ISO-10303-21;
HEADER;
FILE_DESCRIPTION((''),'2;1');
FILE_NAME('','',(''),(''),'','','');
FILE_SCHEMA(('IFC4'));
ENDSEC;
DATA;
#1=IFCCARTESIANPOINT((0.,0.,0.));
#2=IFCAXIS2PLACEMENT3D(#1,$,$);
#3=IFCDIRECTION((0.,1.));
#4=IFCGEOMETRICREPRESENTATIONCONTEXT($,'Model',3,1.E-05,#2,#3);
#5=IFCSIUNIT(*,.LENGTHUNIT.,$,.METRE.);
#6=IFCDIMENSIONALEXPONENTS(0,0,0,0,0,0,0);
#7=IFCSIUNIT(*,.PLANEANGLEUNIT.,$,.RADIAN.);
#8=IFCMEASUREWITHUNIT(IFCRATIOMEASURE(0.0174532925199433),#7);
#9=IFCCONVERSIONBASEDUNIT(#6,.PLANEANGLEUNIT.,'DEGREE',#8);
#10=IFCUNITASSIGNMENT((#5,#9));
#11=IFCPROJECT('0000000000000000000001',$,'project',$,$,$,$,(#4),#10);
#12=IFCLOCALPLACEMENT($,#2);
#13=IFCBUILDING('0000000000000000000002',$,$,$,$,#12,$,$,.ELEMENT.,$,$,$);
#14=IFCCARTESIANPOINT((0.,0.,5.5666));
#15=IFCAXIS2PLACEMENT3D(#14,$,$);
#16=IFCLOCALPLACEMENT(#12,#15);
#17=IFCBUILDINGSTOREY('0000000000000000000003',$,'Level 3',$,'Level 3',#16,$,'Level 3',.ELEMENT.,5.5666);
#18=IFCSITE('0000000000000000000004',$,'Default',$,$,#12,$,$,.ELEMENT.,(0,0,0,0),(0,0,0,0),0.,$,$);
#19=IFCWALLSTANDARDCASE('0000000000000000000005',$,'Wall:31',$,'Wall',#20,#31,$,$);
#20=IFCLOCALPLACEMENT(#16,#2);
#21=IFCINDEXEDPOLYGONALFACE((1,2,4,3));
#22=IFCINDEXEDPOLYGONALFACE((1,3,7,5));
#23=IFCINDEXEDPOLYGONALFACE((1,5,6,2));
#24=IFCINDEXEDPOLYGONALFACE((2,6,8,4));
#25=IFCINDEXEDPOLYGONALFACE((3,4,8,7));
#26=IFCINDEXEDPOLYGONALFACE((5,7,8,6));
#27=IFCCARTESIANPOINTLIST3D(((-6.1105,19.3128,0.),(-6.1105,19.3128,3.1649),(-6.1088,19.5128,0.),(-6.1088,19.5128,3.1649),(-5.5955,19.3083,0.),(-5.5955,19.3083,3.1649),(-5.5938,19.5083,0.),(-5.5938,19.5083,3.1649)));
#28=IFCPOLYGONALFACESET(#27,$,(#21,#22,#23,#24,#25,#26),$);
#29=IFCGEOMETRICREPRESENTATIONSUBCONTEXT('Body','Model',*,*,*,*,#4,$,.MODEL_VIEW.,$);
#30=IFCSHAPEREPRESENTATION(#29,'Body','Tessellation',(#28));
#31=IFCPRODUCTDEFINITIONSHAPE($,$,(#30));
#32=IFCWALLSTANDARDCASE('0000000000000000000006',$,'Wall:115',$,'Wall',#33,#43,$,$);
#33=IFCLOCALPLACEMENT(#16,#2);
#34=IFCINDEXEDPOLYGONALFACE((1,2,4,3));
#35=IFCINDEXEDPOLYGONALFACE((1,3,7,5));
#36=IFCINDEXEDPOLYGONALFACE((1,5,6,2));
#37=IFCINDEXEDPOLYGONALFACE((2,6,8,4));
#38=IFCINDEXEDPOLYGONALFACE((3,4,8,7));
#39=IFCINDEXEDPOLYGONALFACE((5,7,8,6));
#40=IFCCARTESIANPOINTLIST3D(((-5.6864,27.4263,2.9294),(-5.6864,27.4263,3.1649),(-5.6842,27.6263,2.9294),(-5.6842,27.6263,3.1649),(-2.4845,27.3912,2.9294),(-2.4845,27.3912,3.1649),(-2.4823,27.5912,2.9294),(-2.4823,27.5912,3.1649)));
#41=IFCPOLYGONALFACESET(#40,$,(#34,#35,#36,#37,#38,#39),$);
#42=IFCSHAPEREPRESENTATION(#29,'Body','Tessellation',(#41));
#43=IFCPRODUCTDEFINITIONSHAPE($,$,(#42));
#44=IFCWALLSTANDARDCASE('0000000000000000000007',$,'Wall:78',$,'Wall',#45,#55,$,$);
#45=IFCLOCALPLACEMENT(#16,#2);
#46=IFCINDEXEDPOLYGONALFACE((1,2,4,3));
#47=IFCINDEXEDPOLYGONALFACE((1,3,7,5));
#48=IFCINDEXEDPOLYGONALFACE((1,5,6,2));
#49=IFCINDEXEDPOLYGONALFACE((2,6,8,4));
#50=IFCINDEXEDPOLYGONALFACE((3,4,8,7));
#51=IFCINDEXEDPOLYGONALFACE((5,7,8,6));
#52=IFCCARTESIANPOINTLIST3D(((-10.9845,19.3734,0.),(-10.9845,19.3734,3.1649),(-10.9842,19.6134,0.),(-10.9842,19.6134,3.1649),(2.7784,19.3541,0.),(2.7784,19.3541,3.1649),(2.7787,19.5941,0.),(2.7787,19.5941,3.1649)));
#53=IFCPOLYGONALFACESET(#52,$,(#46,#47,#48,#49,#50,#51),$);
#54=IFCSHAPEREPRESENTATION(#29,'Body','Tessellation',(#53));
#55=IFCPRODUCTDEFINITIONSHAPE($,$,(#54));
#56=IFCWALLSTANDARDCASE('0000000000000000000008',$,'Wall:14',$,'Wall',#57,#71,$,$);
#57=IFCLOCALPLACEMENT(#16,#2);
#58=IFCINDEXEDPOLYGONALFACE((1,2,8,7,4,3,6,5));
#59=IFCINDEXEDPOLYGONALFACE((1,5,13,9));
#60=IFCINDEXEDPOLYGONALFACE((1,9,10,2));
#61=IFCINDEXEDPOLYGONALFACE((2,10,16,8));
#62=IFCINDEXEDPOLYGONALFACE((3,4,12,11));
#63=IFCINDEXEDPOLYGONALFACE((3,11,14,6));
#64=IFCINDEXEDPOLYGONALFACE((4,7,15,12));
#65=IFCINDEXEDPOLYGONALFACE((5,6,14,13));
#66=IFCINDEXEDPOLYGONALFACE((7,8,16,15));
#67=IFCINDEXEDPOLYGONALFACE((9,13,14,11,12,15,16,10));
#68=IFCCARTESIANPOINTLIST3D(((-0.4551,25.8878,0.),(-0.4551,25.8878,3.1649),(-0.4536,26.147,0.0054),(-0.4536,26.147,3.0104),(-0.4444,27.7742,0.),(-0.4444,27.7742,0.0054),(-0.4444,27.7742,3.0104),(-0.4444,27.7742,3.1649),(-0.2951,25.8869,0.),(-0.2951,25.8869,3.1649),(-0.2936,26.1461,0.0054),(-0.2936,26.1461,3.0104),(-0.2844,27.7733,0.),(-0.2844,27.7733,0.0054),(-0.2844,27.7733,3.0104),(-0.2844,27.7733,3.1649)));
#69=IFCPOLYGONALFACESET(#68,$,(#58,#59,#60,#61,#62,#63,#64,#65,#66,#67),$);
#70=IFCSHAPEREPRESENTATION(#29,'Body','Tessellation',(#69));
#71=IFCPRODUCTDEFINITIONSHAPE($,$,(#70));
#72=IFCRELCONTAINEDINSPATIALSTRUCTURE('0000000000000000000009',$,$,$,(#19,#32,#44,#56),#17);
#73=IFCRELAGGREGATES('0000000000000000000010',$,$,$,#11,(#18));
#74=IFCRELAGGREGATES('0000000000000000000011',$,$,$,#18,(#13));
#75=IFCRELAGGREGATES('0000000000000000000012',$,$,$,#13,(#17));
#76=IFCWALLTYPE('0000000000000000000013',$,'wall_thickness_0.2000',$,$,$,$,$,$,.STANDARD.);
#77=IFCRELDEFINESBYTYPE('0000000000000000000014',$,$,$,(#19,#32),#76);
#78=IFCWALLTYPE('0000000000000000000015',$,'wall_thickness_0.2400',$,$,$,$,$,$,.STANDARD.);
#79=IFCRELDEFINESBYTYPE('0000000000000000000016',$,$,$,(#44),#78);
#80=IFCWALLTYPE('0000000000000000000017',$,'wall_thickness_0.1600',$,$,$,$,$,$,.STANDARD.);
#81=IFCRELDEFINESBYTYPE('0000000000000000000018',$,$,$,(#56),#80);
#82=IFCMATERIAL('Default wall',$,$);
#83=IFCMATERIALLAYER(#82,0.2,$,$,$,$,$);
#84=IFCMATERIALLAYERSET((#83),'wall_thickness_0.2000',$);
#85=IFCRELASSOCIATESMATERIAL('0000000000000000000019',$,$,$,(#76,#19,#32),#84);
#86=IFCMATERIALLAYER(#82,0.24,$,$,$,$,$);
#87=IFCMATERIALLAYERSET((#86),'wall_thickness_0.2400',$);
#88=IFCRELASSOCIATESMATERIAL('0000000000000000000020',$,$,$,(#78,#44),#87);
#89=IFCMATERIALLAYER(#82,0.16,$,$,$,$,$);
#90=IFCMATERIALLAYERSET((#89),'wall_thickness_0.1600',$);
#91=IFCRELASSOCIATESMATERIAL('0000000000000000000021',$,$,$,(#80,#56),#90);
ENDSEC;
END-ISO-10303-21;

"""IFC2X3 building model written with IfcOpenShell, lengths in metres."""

from ifc_helpers import new_model, entity, si_unit, converted_unit, direction, frame, frame_2d, origin, place, context, subcontext, project, spatial, polyline, rectangle, outline, extrude, material, layer, layer_set, layer_usage, type_object, element, save


model = new_model("IFC2X3")

# Units and contexts
model_context = context("Model", 3, precision=1e-05, world=origin(), true_north=direction((0.0, 1.0)))
body_context = subcontext(model_context, "Body", "Model", "MODEL_VIEW")
ifc_project = project(units=[si_unit("LENGTHUNIT", "METRE"), converted_unit("PLANEANGLEUNIT", "DEGREE", entity("IfcRatioMeasure", 0.0174532925199433), si_unit("PLANEANGLEUNIT", "RADIAN"), dimensions=[0, 0, 0, 0, 0, 0, 0])], contexts=[model_context])

# Site, building, storey
placement_1 = place(None, origin())
site = spatial("IfcSite", under=ifc_project, at=placement_1, Name="Default", CompositionType="ELEMENT", RefLatitude=(0, 0, 0, 0), RefLongitude=(0, 0, 0, 0), RefElevation=0.0)
building = spatial("IfcBuilding", under=site, at=placement_1, CompositionType="ELEMENT")
storey_placement = place(placement_1, frame((0.0, 0.0, 5.5666)))
storey = spatial("IfcBuildingStorey", under=building, at=storey_placement, Name="Level 3", ObjectType="Level 3", LongName="Level 3", CompositionType="ELEMENT", Elevation=5.5666)

# Shared definitions
ifc_material_1 = material(Name="Default wall")

# Walls
ifc_layer_1 = layer(ifc_material_1, 0.2)
ifc_layer_set_1 = layer_set([ifc_layer_1], Name="wall_thickness_0.2000")
ifc_layer_usage_1 = layer_usage(ifc_layer_set_1, "AXIS2", "POSITIVE", -0.1)
wall_type_1 = type_object("IfcWallType", Name="wall_thickness_0.2000", PredefinedType="STANDARD", material=ifc_layer_set_1)
wall_1_placement = place(storey_placement, frame((-6.1097, 19.4128, 0.0), z_axis=(0.0, 0.0, 1.0), x_axis=(0.999962, -0.008726, 0.0)))
element("IfcWallStandardCase", 1, at=wall_1_placement, inside=storey, type_object=wall_type_1, material=ifc_layer_usage_1, Name="Wall:31", ObjectType="Wall", context=body_context, shape_type="SweptSolid", body=[
    extrude(outline(polyline([(0.515, -0.1), (0.515, 0.1), (0.0, 0.1), (0.0, -0.1), (0.515, -0.1)])), origin(), (0.0, 0.0, 1.0), 3.1649),
])
placement_2 = place(placement_1, frame((0.0, 0.0, 8.496)))
wall_2_placement = place(placement_2, frame((-5.6853, 27.5263, 0.0), z_axis=(0.0, 0.0, 1.0), x_axis=(0.99994, -0.010944, 0.0)))
element("IfcWallStandardCase", 2, at=wall_2_placement, inside=storey, type_object=wall_type_1, material=ifc_layer_usage_1, Name="Wall:115", ObjectType="Wall", context=body_context, shape_type="SweptSolid", body=[
    extrude(outline(polyline([(3.202, -0.1), (3.202, 0.1), (0.0, 0.1), (0.0, -0.1), (3.202, -0.1)])), origin(), (0.0, 0.0, 1.0), 0.2355),
])
ifc_layer_2 = layer(ifc_material_1, 0.24)
ifc_layer_set_2 = layer_set([ifc_layer_2], Name="wall_thickness_0.2400")
ifc_layer_usage_2 = layer_usage(ifc_layer_set_2, "AXIS2", "POSITIVE", -0.12)
wall_type_2 = type_object("IfcWallType", Name="wall_thickness_0.2400", PredefinedType="STANDARD", material=ifc_layer_set_2)
wall_3_placement = place(storey_placement, frame((-10.9843, 19.4934, 0.0), z_axis=(0.0, 0.0, 1.0), x_axis=(0.999999, -0.001399, 0.0)))
element("IfcWallStandardCase", 3, at=wall_3_placement, inside=storey, type_object=wall_type_2, material=ifc_layer_usage_2, Name="Wall:78", ObjectType="Wall", context=body_context, shape_type="SweptSolid", body=[
    extrude(outline(polyline([(13.7629, -0.12), (13.7629, 0.12), (0.0, 0.12), (0.0, -0.12), (13.7629, -0.12)])), origin(), (0.0, 0.0, 1.0), 3.1649),
])

# Wall, opening
ifc_layer_3 = layer(ifc_material_1, 0.16)
ifc_layer_set_3 = layer_set([ifc_layer_3], Name="wall_thickness_0.1600")
ifc_layer_usage_3 = layer_usage(ifc_layer_set_3, "AXIS2", "POSITIVE", -0.08)
wall_type_3 = type_object("IfcWallType", Name="wall_thickness_0.1600", PredefinedType="STANDARD", material=ifc_layer_set_3)
wall_4_placement = place(storey_placement, frame((-0.3644, 27.7737, 0.0), z_axis=(0.0, 0.0, 1.0), x_axis=(-0.005654, -0.999984, 0.0)))
wall_4 = element("IfcWallStandardCase", 4, at=wall_4_placement, inside=storey, type_object=wall_type_3, material=ifc_layer_usage_3, Name="Wall:14", ObjectType="Wall", context=body_context, shape_type="SweptSolid", body=[
    extrude(outline(polyline([(1.8864, -0.08), (1.8864, 0.08), (0.0, 0.08), (0.0, -0.08), (1.8864, -0.08)])), origin(), (0.0, 0.0, 1.0), 3.1649),
])
opening_1_placement = place(wall_4_placement, frame((-0.3328, -0.08, 0.0054)))
element("IfcOpeningElement", 5, at=opening_1_placement, cuts=wall_4, ObjectType="Opening", context=body_context, shape_type="SweptSolid", body=[
    extrude(rectangle(XDim=1.96, YDim=3.005, at=frame_2d((1.5025, 0.98), x_axis=(0.0, 1.0))), frame((0.0, 0.0, 0.0), z_axis=(0.0, 1.0, 0.0), x_axis=(0.0, 0.0, 1.0)), (0.0, 0.0, 1.0), 0.16),
])

save(model, "model.ifc")
